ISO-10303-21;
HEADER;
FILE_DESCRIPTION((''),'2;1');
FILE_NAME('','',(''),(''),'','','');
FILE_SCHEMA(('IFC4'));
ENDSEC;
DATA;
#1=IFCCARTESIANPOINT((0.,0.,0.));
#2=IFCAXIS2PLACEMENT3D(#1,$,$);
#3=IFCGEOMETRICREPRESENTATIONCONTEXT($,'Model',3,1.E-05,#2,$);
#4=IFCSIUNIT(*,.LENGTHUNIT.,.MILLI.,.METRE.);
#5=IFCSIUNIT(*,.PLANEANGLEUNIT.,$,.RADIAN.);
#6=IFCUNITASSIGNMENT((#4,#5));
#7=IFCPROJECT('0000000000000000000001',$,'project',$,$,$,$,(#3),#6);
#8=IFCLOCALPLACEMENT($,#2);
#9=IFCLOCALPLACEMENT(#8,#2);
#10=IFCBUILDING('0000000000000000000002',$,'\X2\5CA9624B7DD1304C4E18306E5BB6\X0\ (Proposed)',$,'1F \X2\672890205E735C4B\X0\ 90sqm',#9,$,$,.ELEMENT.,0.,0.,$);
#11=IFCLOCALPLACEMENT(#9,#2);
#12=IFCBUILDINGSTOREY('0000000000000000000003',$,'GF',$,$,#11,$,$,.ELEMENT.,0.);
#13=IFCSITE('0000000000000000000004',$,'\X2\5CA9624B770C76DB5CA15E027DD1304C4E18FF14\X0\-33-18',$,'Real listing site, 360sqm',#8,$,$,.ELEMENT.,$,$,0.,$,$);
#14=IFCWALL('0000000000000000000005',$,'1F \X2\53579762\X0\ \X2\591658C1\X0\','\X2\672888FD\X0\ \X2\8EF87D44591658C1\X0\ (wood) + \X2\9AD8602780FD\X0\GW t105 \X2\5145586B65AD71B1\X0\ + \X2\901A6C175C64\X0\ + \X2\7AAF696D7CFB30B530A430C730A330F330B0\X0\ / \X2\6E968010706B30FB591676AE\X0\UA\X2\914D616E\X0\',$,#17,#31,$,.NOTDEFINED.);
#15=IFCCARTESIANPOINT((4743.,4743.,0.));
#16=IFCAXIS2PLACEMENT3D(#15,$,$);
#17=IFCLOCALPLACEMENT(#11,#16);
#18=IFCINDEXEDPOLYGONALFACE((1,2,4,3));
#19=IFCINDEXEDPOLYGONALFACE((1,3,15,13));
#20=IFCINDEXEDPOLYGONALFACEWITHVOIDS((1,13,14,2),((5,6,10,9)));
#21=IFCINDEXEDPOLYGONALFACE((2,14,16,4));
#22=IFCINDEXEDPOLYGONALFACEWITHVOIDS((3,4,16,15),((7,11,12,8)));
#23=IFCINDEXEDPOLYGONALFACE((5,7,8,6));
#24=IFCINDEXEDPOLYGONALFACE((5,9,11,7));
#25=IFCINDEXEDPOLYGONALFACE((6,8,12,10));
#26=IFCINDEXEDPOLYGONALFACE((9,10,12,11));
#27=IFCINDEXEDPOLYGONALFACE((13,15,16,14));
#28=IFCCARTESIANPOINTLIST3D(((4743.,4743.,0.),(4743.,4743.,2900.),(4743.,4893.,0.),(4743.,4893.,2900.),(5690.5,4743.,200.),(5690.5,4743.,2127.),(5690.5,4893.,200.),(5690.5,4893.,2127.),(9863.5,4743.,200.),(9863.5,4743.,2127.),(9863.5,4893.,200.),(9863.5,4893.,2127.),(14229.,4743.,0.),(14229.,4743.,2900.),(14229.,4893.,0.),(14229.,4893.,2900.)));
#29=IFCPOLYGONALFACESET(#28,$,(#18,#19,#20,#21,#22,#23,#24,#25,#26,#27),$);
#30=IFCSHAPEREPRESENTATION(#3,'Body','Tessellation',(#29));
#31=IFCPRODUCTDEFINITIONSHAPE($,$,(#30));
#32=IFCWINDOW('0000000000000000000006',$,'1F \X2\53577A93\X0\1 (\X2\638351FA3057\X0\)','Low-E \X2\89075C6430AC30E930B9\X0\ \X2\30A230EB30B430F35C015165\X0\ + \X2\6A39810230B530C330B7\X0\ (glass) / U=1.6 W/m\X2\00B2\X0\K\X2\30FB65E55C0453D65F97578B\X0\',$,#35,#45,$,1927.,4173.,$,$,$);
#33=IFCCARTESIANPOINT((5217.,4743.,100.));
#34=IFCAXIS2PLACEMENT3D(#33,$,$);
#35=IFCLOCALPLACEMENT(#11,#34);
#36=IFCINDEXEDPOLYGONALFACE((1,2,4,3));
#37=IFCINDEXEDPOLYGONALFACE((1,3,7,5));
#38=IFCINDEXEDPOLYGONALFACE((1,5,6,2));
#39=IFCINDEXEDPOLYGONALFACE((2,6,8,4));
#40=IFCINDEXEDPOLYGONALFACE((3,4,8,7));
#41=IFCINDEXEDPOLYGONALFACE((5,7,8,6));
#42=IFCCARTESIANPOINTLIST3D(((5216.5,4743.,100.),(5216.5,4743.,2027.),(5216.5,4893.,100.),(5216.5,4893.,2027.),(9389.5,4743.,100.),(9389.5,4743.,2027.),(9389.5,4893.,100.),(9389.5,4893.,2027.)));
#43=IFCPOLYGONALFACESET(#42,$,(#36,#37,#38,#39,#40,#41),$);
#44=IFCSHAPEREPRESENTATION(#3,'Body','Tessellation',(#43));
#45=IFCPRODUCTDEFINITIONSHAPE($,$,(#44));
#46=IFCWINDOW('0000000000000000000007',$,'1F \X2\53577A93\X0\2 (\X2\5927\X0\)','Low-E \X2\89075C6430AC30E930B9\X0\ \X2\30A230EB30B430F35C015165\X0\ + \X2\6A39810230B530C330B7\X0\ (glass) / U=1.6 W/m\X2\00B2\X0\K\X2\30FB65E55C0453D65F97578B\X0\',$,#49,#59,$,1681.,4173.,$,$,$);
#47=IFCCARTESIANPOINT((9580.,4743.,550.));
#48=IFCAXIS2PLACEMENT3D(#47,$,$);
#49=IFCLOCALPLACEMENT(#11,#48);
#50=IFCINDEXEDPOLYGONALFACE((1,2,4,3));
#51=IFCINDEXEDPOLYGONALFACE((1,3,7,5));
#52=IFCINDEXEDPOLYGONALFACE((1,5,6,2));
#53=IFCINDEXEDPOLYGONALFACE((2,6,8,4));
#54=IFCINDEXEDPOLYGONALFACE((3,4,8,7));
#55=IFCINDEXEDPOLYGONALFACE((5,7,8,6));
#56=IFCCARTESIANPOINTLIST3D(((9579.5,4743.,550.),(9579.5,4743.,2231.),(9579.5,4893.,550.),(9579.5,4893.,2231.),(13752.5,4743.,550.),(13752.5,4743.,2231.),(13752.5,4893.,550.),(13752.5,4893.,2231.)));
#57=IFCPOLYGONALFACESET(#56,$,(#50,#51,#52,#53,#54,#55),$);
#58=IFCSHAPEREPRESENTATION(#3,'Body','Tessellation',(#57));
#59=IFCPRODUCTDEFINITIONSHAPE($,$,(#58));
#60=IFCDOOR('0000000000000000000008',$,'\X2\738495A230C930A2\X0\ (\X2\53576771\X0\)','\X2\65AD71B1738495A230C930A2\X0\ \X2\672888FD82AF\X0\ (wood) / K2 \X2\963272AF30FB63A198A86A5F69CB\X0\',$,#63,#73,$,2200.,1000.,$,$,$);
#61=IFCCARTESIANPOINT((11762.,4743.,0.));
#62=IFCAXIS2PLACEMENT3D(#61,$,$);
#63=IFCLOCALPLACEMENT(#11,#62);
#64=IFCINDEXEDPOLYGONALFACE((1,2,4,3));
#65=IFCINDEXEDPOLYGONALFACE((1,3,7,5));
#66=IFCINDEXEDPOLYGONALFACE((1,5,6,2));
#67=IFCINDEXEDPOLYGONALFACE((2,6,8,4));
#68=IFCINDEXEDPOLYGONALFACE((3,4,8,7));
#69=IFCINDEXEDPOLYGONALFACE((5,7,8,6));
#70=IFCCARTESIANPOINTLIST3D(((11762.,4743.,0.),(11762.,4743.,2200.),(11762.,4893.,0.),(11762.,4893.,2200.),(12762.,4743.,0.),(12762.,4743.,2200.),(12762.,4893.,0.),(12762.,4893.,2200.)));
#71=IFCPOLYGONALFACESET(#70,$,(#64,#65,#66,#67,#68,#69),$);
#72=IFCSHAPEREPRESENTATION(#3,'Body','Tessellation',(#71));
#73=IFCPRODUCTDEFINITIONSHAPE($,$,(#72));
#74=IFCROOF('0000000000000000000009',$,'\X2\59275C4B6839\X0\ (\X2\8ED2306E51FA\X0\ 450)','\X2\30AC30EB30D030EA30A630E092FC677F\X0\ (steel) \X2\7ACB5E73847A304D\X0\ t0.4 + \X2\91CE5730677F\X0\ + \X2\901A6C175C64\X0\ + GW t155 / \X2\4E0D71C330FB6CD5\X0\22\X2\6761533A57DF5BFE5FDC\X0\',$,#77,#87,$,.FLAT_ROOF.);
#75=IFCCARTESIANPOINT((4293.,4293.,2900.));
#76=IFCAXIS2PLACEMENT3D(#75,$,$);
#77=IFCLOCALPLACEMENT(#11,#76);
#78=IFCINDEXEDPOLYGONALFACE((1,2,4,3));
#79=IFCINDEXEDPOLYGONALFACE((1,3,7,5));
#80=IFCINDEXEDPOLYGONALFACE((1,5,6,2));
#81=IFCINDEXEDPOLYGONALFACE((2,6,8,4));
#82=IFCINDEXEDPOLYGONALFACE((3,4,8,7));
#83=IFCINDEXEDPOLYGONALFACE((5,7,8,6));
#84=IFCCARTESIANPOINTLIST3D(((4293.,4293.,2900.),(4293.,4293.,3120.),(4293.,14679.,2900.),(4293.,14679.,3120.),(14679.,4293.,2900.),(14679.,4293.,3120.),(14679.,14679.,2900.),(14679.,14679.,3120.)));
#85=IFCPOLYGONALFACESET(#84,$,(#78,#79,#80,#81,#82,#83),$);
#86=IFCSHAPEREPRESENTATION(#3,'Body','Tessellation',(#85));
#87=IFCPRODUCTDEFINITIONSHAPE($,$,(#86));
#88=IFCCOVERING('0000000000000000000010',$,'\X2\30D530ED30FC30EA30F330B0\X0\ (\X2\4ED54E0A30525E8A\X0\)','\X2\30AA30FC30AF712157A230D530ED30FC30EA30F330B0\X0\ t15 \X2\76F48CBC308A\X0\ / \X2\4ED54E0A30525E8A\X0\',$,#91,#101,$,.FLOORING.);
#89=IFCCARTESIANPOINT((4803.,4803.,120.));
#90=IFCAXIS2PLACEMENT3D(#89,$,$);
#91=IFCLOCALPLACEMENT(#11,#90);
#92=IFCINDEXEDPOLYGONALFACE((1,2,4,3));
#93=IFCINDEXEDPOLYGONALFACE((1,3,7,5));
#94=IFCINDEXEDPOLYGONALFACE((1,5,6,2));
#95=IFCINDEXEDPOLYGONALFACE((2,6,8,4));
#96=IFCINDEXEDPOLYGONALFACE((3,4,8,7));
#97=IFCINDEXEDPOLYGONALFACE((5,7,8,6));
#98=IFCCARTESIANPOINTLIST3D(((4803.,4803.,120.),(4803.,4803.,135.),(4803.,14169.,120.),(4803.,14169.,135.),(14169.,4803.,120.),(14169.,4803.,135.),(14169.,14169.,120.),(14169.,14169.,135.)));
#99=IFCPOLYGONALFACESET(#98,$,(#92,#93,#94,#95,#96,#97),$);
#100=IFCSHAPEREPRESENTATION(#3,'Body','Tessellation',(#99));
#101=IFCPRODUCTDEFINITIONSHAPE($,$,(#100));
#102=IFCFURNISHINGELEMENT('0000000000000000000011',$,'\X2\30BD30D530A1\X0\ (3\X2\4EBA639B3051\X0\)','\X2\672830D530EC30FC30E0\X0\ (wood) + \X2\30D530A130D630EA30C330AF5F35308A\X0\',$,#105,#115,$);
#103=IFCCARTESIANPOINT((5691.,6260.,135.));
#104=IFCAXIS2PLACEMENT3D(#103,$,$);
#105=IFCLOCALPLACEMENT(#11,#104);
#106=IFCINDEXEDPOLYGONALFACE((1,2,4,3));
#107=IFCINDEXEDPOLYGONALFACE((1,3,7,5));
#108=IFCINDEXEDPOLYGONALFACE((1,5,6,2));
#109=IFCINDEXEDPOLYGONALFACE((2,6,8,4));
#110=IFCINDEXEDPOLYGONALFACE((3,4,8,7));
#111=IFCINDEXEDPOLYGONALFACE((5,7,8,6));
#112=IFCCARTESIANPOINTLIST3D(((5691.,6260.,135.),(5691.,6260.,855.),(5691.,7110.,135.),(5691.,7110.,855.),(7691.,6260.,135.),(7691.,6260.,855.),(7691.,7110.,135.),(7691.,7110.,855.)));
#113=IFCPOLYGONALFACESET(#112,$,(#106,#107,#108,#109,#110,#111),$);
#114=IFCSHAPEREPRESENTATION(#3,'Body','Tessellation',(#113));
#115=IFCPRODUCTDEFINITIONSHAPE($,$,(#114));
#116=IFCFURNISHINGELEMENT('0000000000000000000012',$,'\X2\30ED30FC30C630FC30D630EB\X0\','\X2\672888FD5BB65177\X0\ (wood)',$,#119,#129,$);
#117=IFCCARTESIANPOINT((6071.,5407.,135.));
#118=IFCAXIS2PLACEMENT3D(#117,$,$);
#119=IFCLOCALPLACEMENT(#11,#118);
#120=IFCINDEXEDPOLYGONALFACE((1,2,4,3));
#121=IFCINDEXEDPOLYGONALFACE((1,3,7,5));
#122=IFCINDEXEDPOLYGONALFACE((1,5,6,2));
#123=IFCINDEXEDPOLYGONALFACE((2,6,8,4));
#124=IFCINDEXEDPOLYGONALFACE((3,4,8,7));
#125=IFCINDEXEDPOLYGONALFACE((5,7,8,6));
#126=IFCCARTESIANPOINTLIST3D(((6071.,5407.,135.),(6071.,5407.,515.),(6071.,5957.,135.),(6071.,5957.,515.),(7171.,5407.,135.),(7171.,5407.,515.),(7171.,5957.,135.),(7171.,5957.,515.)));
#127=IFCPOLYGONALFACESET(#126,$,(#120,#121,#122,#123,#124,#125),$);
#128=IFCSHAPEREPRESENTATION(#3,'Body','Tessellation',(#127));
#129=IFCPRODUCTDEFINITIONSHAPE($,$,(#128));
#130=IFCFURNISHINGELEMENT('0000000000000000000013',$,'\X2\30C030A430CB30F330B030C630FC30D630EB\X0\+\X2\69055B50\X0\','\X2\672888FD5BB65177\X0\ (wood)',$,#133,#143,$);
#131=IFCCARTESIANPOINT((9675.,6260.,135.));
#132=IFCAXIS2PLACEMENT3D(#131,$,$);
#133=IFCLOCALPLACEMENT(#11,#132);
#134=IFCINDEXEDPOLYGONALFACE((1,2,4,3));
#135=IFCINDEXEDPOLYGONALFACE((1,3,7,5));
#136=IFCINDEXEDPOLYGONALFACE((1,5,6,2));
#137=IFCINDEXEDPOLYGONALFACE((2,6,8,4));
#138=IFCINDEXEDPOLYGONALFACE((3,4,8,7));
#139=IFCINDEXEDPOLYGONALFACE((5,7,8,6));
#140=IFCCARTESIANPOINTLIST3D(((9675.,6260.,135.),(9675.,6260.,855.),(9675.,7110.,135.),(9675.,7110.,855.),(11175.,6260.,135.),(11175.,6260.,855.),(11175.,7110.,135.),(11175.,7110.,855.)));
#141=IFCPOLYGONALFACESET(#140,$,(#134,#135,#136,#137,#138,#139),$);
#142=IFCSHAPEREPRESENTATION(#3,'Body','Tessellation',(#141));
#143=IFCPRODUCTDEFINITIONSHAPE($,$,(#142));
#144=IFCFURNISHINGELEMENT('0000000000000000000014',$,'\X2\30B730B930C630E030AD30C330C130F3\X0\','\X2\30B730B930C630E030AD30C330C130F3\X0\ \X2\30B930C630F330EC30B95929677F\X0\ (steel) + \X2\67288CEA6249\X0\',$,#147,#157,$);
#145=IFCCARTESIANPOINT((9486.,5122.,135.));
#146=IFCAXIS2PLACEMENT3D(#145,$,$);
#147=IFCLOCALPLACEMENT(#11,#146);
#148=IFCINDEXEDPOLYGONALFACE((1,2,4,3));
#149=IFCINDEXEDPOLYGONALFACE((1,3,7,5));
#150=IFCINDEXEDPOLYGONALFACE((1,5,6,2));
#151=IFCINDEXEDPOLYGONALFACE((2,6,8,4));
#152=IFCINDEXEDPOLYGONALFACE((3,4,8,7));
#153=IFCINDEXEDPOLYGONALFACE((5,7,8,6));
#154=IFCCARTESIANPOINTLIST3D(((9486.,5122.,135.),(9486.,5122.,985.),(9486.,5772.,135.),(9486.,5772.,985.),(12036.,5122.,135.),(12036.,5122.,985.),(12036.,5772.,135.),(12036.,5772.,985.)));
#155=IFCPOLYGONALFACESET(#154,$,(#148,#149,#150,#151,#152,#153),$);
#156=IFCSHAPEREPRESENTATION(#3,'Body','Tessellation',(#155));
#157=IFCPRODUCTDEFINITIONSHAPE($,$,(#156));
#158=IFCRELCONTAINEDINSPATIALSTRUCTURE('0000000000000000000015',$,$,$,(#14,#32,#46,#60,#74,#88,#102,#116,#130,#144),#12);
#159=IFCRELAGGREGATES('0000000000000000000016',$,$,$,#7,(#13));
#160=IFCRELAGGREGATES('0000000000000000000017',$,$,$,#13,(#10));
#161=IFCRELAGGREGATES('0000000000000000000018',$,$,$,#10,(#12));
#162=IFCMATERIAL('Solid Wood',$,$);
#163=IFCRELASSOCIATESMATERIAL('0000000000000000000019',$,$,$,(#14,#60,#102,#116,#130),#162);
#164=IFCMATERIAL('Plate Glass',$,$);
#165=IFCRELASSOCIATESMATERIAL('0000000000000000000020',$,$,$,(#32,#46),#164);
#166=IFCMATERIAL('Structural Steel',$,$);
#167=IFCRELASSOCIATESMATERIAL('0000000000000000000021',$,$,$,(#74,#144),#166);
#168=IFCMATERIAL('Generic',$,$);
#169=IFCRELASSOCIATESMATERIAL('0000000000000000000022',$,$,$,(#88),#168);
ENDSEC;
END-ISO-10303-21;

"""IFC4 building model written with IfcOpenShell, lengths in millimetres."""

from ifc_helpers import new_model, si_unit, frame, frame_2d, origin, place, context, project, spatial, rectangle, extrude, material, element, fill, save


model = new_model("IFC4")

# Units and contexts
model_context = context("Model", 3, precision=1e-05, world=origin())
ifc_project = project(units=[si_unit("LENGTHUNIT", "METRE", prefix="MILLI"), si_unit("PLANEANGLEUNIT", "RADIAN")], contexts=[model_context])

# Site, building, storey
site_placement = place(None, origin())
site = spatial("IfcSite", under=ifc_project, at=site_placement, Name="岩手県盛岡市緑が丘４-33-18", ObjectType="Real listing site, 360sqm", CompositionType="ELEMENT", RefElevation=0.0)
building_placement = place(site_placement, origin())
building = spatial("IfcBuilding", under=site, at=building_placement, Name="岩手緑が丘の家 (Proposed)", ObjectType="1F 木造平屋 90sqm", CompositionType="ELEMENT", ElevationOfRefHeight=0.0, ElevationOfTerrain=0.0)
storey_placement = place(building_placement, origin())
storey = spatial("IfcBuildingStorey", under=building, at=storey_placement, Name="GF", CompositionType="ELEMENT", Elevation=0.0)

# Shared definitions
ifc_material_1 = material(Name="Solid Wood")

# Wall, openings, windows, door
wall_1_placement = place(storey_placement, frame((4743.0, 4743.0, 0.0)))
wall_1 = element("IfcWall", 1, at=wall_1_placement, inside=storey, material=ifc_material_1, Name="1F 南面 外壁", Description="木製 軸組外壁 (wood) + 高性能GW t105 充填断熱 + 通気層 + 窯業系サイディング / 準耐火・外皮UA配慮", PredefinedType="NOTDEFINED", context=model_context, shape_type="SweptSolid", body=[
    extrude(rectangle(XDim=9486.0, YDim=150.0, at=frame_2d((4743.0, 75.0))), frame((4743.0, 4743.0, 0.0)), (0.0, 0.0, 1.0), 2900.0),
])
opening_1_placement = place(storey_placement, frame((5217.0, 4743.0, 100.0)))
opening_1 = element("IfcOpeningElement", 2, at=opening_1_placement, cuts=wall_1, PredefinedType="NOTDEFINED", context=model_context, shape_type="SweptSolid", body=[
    extrude(rectangle(XDim=4173.0, YDim=150.0, at=frame_2d((2086.0, 75.0))), frame((5217.0, 4743.0, 100.0)), (0.0, 0.0, 1.0), 1927.0),
])
opening_2_placement = place(storey_placement, frame((9580.0, 4743.0, 550.0)))
opening_2 = element("IfcOpeningElement", 3, at=opening_2_placement, cuts=wall_1, PredefinedType="NOTDEFINED", context=model_context, shape_type="SweptSolid", body=[
    extrude(rectangle(XDim=4173.0, YDim=150.0, at=frame_2d((2086.0, 75.0))), frame((9580.0, 4743.0, 550.0)), (0.0, 0.0, 1.0), 1681.0),
])
opening_3_placement = place(storey_placement, frame((11762.0, 4743.0, 0.0)))
opening_3 = element("IfcOpeningElement", 4, at=opening_3_placement, cuts=wall_1, PredefinedType="NOTDEFINED", context=model_context, shape_type="SweptSolid", body=[
    extrude(rectangle(XDim=1000.0, YDim=150.0, at=frame_2d((500.0, 75.0))), frame((11762.0, 4743.0, 0.0)), (0.0, 0.0, 1.0), 2200.0),
])
ifc_material_2 = material(Name="Plate Glass")
window_1_placement = place(storey_placement, frame((5217.0, 4743.0, 100.0)))
window_1 = element("IfcWindow", 5, at=window_1_placement, inside=storey, material=ifc_material_2, Name="1F 南窓1 (掃出し)", Description="Low-E 複層ガラス アルゴン封入 + 樹脂サッシ (glass) / U=1.6 W/m²K・日射取得型", OverallHeight=1927.0, OverallWidth=4173.0, context=model_context, shape_type="SweptSolid", body=[
    extrude(rectangle(XDim=4173.0, YDim=150.0, at=frame_2d((2086.0, 75.0))), frame((5217.0, 4743.0, 100.0)), (0.0, 0.0, 1.0), 1927.0),
])
fill(opening_1, window_1)
window_2_placement = place(storey_placement, frame((9580.0, 4743.0, 550.0)))
window_2 = element("IfcWindow", 6, at=window_2_placement, inside=storey, material=ifc_material_2, Name="1F 南窓2 (大)", Description="Low-E 複層ガラス アルゴン封入 + 樹脂サッシ (glass) / U=1.6 W/m²K・日射取得型", OverallHeight=1681.0, OverallWidth=4173.0, context=model_context, shape_type="SweptSolid", body=[
    extrude(rectangle(XDim=4173.0, YDim=150.0, at=frame_2d((2086.0, 75.0))), frame((9580.0, 4743.0, 550.0)), (0.0, 0.0, 1.0), 1681.0),
])
fill(opening_2, window_2)
door_placement = place(storey_placement, frame((11762.0, 4743.0, 0.0)))
door = element("IfcDoor", 7, at=door_placement, inside=storey, material=ifc_material_1, Name="玄関ドア (南東)", Description="断熱玄関ドア 木製芯 (wood) / K2 防犯・採風機構", OverallHeight=2200.0, OverallWidth=1000.0, context=model_context, shape_type="SweptSolid", body=[
    extrude(rectangle(XDim=1000.0, YDim=150.0, at=frame_2d((500.0, 75.0))), frame((11762.0, 4743.0, 0.0)), (0.0, 0.0, 1.0), 2200.0),
])
fill(opening_3, door)

# Roof
ifc_material_3 = material(Name="Structural Steel")
roof_placement = place(storey_placement, frame((4293.0, 4293.0, 2900.0)))
element("IfcRoof", 8, at=roof_placement, inside=storey, material=ifc_material_3, Name="大屋根 (軒の出 450)", Description="ガルバリウム鋼板 (steel) 立平葺き t0.4 + 野地板 + 通気層 + GW t155 / 不燃・法22条区域対応", PredefinedType="FLAT_ROOF", context=model_context, shape_type="SweptSolid", body=[
    extrude(rectangle(XDim=10386.0, YDim=10386.0, at=frame_2d((5193.0, 5193.0))), frame((4293.0, 4293.0, 2900.0)), (0.0, 0.0, 1.0), 220.0),
])

# Covering
ifc_material_4 = material(Name="Generic")
covering_placement = place(storey_placement, frame((4803.0, 4803.0, 120.0)))
element("IfcCovering", 9, at=covering_placement, inside=storey, material=ifc_material_4, Name="フローリング (仕上げ床)", Description="オーク無垢フローリング t15 直貼り / 仕上げ床", PredefinedType="FLOORING", context=model_context, shape_type="SweptSolid", body=[
    extrude(rectangle(XDim=9366.0, YDim=9366.0, at=frame_2d((4683.0, 4683.0))), frame((4803.0, 4803.0, 120.0)), (0.0, 0.0, 1.0), 15.0),
])

# Furnishing elements
furnishing_1_placement = place(storey_placement, frame((5691.0, 6260.0, 135.0)))
element("IfcFurnishingElement", 10, at=furnishing_1_placement, inside=storey, material=ifc_material_1, Name="ソファ (3人掛け)", Description="木フレーム (wood) + ファブリック張り", context=model_context, shape_type="SweptSolid", body=[
    extrude(rectangle(XDim=2000.0, YDim=850.0, at=frame_2d((1000.0, 425.0))), frame((5691.0, 6260.0, 135.0)), (0.0, 0.0, 1.0), 720.0),
])
furnishing_2_placement = place(storey_placement, frame((6071.0, 5407.0, 135.0)))
element("IfcFurnishingElement", 11, at=furnishing_2_placement, inside=storey, material=ifc_material_1, Name="ローテーブル", Description="木製家具 (wood)", context=model_context, shape_type="SweptSolid", body=[
    extrude(rectangle(XDim=1100.0, YDim=550.0, at=frame_2d((550.0, 275.0))), frame((6071.0, 5407.0, 135.0)), (0.0, 0.0, 1.0), 380.0),
])
furnishing_3_placement = place(storey_placement, frame((9675.0, 6260.0, 135.0)))
element("IfcFurnishingElement", 12, at=furnishing_3_placement, inside=storey, material=ifc_material_1, Name="ダイニングテーブル+椅子", Description="木製家具 (wood)", context=model_context, shape_type="SweptSolid", body=[
    extrude(rectangle(XDim=1500.0, YDim=850.0, at=frame_2d((750.0, 425.0))), frame((9675.0, 6260.0, 135.0)), (0.0, 0.0, 1.0), 720.0),
])
furnishing_4_placement = place(storey_placement, frame((9486.0, 5122.0, 135.0)))
element("IfcFurnishingElement", 13, at=furnishing_4_placement, inside=storey, material=ifc_material_3, Name="システムキッチン", Description="システムキッチン ステンレス天板 (steel) + 木質扉", context=model_context, shape_type="SweptSolid", body=[
    extrude(rectangle(XDim=2550.0, YDim=650.0, at=frame_2d((1275.0, 325.0))), frame((9486.0, 5122.0, 135.0)), (0.0, 0.0, 1.0), 850.0),
])

save(model, "model.ifc")
